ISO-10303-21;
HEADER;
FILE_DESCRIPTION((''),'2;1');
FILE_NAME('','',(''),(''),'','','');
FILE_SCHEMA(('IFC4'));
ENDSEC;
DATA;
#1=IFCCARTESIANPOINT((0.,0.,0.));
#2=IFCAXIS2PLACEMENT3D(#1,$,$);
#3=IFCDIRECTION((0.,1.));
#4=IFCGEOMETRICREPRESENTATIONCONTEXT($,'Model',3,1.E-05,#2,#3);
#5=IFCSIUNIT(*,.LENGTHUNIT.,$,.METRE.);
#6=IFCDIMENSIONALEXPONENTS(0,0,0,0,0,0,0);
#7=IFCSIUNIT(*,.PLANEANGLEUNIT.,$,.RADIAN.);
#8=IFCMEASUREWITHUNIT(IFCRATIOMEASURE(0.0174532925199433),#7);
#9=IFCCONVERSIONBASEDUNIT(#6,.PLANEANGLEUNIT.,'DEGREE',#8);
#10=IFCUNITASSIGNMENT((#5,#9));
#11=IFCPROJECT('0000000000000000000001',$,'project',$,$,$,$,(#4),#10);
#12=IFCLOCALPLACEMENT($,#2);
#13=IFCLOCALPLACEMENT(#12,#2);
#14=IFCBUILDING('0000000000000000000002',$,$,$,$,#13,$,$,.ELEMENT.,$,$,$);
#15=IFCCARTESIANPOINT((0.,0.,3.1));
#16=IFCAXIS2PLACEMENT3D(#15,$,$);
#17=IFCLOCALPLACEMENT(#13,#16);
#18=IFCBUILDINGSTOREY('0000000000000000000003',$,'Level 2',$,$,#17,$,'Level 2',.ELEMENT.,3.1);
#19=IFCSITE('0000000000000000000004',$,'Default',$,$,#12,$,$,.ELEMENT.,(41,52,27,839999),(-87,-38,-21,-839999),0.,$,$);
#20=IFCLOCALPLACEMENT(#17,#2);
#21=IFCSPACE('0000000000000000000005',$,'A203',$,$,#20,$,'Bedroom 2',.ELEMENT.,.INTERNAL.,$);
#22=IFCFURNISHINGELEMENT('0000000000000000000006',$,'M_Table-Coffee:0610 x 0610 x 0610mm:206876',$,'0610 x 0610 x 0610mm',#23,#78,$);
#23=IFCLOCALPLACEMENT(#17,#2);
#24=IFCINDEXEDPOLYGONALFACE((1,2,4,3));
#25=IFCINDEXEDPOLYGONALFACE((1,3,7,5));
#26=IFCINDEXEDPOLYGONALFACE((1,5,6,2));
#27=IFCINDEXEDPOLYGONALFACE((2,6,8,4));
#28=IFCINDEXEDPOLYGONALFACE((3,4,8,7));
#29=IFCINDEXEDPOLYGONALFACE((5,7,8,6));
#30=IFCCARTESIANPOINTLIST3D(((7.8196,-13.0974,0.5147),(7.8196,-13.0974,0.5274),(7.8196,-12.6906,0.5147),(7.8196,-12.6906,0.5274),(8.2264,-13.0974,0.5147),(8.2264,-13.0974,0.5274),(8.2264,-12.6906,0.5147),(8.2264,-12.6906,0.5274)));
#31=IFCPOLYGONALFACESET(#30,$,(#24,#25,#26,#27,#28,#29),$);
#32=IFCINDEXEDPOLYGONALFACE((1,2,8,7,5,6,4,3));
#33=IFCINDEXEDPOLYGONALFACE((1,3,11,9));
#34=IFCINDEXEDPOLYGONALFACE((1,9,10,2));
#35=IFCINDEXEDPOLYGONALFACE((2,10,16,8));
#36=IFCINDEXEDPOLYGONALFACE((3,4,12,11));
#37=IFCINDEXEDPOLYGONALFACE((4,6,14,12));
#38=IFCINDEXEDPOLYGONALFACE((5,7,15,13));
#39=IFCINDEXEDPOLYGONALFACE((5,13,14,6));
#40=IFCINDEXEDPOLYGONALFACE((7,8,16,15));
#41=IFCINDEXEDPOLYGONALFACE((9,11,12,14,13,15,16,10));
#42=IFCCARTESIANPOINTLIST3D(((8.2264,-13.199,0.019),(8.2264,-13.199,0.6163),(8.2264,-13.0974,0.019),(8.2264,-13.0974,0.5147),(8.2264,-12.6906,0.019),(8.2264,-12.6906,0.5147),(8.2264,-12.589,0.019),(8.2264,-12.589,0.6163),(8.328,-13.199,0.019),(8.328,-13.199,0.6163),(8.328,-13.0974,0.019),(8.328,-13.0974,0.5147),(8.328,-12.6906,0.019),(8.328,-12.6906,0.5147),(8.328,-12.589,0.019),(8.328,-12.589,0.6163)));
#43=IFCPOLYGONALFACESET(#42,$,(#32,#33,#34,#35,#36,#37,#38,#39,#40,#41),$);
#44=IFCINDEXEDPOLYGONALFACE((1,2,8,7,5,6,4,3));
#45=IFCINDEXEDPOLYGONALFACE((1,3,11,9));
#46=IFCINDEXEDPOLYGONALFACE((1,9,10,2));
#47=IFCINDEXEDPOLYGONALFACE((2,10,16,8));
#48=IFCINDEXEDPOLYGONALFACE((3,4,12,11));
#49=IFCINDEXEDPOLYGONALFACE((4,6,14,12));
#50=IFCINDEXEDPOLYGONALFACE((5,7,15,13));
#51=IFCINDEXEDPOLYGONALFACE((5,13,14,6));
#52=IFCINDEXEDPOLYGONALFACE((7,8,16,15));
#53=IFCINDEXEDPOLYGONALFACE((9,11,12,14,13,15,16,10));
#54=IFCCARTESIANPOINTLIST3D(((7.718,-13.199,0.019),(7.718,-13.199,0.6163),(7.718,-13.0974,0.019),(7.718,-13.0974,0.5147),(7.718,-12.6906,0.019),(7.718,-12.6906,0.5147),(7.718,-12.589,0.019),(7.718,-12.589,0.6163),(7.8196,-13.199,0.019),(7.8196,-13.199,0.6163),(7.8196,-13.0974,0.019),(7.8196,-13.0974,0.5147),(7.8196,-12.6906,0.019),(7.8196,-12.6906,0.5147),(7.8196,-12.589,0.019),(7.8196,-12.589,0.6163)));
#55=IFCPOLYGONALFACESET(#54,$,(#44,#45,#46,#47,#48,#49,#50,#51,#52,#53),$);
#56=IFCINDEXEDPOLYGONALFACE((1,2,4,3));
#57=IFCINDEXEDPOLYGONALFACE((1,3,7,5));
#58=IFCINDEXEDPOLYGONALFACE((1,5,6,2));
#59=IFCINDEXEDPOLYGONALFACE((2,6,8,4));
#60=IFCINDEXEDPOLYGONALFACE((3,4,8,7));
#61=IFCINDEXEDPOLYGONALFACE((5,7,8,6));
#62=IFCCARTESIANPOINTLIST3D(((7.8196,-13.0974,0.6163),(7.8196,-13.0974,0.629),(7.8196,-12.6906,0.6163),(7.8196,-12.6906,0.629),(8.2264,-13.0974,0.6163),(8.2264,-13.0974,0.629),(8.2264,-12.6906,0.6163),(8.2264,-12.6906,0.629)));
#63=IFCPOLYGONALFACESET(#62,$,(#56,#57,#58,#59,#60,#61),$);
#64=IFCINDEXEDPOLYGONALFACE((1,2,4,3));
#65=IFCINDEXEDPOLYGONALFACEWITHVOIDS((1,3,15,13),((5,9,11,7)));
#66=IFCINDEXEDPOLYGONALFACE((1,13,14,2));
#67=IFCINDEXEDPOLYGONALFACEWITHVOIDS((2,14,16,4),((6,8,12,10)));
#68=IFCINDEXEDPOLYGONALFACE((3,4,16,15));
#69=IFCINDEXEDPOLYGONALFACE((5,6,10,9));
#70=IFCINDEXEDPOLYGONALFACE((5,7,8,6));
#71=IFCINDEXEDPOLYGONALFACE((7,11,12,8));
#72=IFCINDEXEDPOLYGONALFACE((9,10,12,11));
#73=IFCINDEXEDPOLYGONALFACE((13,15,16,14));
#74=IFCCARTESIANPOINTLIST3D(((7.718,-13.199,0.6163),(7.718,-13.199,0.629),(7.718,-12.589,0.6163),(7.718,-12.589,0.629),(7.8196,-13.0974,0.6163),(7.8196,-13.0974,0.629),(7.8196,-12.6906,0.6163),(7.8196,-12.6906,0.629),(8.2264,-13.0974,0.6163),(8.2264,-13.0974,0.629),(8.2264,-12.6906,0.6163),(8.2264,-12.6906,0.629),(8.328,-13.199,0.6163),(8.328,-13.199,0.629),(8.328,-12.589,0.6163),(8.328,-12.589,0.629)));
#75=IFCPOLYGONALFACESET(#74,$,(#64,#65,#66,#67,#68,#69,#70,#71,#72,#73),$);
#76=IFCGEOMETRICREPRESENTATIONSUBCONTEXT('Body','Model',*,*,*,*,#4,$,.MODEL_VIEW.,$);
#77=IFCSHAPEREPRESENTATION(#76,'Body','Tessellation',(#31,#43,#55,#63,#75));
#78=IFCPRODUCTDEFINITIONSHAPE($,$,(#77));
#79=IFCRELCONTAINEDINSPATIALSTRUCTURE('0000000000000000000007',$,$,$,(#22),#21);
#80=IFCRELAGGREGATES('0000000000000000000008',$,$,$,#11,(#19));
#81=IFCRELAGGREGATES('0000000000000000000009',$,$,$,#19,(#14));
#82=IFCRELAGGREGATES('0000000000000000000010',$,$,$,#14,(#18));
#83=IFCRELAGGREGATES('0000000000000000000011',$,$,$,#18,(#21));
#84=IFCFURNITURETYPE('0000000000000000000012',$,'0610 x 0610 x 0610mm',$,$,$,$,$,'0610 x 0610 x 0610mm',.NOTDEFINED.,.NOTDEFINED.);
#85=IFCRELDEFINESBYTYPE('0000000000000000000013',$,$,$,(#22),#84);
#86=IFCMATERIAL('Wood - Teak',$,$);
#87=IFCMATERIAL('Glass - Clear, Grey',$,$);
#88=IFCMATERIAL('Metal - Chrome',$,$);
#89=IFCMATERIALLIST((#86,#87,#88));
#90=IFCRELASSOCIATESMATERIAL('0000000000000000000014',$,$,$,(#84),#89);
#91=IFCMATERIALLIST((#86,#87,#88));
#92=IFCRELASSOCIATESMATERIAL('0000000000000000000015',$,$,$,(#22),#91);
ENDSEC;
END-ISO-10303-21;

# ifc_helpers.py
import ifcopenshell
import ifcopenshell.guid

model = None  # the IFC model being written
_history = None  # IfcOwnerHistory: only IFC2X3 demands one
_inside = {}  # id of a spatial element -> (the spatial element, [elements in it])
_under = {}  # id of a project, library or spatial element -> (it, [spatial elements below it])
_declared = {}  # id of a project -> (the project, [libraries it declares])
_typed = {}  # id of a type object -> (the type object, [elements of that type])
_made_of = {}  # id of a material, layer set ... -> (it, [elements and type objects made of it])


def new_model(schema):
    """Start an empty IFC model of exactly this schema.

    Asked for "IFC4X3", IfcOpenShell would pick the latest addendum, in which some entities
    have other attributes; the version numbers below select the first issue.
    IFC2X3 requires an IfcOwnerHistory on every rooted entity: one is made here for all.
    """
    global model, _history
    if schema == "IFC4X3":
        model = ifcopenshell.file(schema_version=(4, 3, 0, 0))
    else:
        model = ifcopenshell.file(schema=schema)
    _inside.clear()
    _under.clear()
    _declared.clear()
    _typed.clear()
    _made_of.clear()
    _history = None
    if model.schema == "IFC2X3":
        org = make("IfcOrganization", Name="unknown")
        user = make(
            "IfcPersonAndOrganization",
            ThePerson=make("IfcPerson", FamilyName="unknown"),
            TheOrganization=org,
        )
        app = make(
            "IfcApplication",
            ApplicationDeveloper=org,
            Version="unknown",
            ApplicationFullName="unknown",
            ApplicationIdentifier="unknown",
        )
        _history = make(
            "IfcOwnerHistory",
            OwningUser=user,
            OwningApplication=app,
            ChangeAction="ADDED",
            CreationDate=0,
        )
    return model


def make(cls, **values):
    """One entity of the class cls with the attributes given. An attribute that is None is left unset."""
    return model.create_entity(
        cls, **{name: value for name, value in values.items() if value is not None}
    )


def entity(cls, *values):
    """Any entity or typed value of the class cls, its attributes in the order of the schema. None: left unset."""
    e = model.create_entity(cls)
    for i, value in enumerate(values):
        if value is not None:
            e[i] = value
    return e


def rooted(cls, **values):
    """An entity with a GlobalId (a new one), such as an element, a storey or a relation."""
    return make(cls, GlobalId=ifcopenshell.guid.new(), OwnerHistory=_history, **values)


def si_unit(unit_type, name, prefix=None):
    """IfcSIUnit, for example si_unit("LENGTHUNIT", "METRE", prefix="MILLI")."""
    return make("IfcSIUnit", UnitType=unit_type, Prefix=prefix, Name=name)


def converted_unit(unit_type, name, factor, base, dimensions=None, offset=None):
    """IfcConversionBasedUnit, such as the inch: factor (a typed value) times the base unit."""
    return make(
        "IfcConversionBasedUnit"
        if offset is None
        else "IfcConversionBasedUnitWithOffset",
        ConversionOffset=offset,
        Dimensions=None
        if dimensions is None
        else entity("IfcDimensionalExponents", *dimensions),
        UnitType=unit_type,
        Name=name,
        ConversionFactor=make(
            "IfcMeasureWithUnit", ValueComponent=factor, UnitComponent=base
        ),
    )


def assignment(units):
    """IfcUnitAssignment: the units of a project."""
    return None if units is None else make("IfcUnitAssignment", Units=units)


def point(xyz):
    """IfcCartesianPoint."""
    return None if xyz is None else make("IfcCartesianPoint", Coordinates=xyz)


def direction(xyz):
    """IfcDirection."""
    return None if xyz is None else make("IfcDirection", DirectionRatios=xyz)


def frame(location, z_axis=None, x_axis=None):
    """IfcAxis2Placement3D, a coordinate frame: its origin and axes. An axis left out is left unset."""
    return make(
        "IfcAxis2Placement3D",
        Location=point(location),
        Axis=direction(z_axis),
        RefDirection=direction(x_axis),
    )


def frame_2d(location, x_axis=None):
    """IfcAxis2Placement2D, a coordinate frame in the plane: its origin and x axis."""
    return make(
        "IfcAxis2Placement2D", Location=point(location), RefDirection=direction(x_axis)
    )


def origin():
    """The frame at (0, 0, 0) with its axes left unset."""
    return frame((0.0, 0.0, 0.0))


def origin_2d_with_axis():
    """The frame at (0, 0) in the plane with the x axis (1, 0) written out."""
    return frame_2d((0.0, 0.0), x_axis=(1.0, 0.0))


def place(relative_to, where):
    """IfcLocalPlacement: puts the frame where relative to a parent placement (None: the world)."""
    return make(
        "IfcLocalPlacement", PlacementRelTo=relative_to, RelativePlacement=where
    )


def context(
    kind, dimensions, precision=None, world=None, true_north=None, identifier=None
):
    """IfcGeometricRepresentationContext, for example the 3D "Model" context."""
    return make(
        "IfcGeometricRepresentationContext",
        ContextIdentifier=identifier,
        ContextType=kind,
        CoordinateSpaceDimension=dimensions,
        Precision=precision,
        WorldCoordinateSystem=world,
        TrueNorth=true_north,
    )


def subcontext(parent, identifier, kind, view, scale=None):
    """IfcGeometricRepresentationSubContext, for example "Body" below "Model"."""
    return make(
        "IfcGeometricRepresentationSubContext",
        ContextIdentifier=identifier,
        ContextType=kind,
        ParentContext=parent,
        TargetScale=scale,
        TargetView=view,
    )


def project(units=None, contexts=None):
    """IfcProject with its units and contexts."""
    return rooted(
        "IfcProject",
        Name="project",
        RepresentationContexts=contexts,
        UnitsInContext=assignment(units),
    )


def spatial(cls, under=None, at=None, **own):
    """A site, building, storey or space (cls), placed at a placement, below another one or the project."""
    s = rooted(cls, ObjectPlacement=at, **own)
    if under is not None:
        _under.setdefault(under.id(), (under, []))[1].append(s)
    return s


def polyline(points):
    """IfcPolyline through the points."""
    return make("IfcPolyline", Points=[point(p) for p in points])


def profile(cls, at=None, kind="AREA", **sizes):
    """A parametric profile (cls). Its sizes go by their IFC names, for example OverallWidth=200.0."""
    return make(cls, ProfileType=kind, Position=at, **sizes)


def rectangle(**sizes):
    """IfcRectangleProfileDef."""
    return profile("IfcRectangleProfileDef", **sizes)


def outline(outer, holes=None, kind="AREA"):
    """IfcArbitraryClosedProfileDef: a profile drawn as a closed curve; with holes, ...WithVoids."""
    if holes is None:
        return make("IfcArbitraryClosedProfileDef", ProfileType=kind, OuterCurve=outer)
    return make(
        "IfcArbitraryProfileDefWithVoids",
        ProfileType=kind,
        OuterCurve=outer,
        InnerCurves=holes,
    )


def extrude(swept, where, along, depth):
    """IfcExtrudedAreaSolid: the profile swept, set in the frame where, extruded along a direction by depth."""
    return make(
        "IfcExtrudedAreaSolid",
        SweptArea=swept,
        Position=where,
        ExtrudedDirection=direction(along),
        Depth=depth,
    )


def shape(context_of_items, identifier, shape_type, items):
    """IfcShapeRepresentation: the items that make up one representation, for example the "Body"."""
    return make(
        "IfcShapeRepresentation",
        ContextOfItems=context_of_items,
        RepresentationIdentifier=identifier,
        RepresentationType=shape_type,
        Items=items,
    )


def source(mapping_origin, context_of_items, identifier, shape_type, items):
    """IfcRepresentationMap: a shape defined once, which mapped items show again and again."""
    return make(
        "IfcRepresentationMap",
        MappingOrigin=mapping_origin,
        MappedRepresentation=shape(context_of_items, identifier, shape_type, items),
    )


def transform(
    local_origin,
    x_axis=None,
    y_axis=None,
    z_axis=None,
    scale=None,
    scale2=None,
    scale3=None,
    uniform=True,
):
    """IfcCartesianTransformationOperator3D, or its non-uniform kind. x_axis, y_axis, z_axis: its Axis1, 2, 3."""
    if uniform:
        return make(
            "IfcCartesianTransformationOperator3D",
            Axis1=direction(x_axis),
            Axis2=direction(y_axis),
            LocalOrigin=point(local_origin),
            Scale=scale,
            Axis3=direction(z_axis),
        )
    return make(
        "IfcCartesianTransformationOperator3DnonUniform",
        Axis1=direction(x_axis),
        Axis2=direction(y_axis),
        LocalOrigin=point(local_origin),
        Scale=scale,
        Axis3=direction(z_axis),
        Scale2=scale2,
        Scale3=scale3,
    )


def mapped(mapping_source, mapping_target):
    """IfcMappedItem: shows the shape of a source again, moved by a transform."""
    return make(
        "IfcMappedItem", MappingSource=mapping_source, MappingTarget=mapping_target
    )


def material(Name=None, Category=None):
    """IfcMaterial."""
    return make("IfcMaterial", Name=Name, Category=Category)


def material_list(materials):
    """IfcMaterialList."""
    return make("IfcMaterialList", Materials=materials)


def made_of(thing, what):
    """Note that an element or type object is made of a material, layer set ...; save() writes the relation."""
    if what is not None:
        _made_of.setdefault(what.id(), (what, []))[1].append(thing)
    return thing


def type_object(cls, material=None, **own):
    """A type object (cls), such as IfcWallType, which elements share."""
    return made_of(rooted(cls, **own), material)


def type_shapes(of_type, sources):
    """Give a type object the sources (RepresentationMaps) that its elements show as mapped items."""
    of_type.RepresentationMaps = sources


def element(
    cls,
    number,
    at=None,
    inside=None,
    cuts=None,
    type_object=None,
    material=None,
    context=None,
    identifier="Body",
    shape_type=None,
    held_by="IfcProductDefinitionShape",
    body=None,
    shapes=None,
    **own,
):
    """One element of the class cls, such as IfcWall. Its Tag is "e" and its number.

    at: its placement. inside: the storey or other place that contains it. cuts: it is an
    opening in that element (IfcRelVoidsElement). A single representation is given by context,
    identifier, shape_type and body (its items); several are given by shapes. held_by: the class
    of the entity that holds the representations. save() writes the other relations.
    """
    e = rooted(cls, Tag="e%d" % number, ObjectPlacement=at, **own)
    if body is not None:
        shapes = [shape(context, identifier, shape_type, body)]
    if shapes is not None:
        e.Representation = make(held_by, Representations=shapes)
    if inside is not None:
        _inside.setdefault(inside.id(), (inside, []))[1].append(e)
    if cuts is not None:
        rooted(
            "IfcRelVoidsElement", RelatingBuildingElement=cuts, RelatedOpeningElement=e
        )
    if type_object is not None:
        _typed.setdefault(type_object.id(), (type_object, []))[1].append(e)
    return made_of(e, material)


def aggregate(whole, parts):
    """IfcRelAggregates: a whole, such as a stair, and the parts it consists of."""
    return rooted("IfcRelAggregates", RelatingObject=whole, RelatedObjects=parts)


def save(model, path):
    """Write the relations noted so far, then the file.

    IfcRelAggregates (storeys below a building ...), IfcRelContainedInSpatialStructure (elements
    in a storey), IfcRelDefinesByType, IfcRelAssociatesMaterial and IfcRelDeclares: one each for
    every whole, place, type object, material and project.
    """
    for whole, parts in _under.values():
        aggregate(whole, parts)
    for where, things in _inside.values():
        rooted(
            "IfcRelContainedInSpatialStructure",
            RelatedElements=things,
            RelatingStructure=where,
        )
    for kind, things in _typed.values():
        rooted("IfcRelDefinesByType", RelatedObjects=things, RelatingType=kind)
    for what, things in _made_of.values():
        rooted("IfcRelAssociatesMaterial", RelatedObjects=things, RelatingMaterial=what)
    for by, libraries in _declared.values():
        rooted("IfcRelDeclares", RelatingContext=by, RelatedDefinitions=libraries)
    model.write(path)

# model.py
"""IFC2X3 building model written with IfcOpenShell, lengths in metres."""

from ifc_helpers import new_model, entity, si_unit, converted_unit, direction, frame, origin, origin_2d_with_axis, place, context, subcontext, project, spatial, polyline, rectangle, outline, extrude, source, transform, mapped, material, material_list, type_object, type_shapes, element, save


model = new_model("IFC2X3")

# Units and contexts
model_context = context("Model", 3, precision=1e-05, world=origin(), true_north=direction((0.0, 1.0)))
body_context = subcontext(model_context, "Body", "Model", "MODEL_VIEW")
ifc_project = project(units=[si_unit("LENGTHUNIT", "METRE"), converted_unit("PLANEANGLEUNIT", "DEGREE", entity("IfcRatioMeasure", 0.0174532925199433), si_unit("PLANEANGLEUNIT", "RADIAN"), dimensions=[0, 0, 0, 0, 0, 0, 0])], contexts=[model_context])

# Site, building, storey
site_placement = place(None, origin())
site = spatial("IfcSite", under=ifc_project, at=site_placement, Name="Default", CompositionType="ELEMENT", RefLatitude=(41, 52, 27, 839999), RefLongitude=(-87, -38, -21, -839999), RefElevation=0.0)
building_placement = place(site_placement, origin())
building = spatial("IfcBuilding", under=site, at=building_placement, CompositionType="ELEMENT")
storey_placement = place(building_placement, frame((0.0, 0.0, 3.1)))
storey = spatial("IfcBuildingStorey", under=building, at=storey_placement, Name="Level 2", LongName="Level 2", CompositionType="ELEMENT", Elevation=3.1)

# Shared definitions
space_1_placement = place(storey_placement, origin())
space_1 = spatial("IfcSpace", under=storey, at=space_1_placement, Name="A203", LongName="Bedroom 2", CompositionType="ELEMENT", InteriorOrExteriorSpace="INTERNAL")

# Furnishing element
ifc_material_1 = material(Name="Wood - Teak")
ifc_material_2 = material(Name="Glass - Clear, Grey")
ifc_material_3 = material(Name="Metal - Chrome")
ifc_material_list_1 = material_list([ifc_material_1, ifc_material_2, ifc_material_3])
ifc_material_list_2 = material_list([ifc_material_1, ifc_material_2, ifc_material_3])
furniture_type_1 = type_object("IfcFurnitureType", Name="0610 x 0610 x 0610mm", ElementType="0610 x 0610 x 0610mm", material=ifc_material_list_2)
shared_shape_1 = source(origin(), body_context, "Body", "SweptSolid", [
    extrude(rectangle(XDim=0.4068, YDim=0.4068, at=origin_2d_with_axis()), frame((0.0183, 0.0952, 0.4957), z_axis=(0.0, 0.0, 1.0), x_axis=(-1.0, 0.0, 0.0)), (0.0, 0.0, 1.0), 0.0127),
    extrude(outline(polyline([(-0.2732, -0.305), (0.324, -0.305), (0.324, 0.305), (-0.2732, 0.305), (-0.2732, 0.2034), (0.2225, 0.2034), (0.2225, -0.2034), (-0.2732, -0.2034), (-0.2732, -0.305)])), frame((0.2217, 0.0952, 0.2732), z_axis=(1.0, 0.0, 0.0), x_axis=(0.0, 0.0, 1.0)), (0.0, 0.0, 1.0), 0.1016),
    extrude(outline(polyline([(-0.305, -0.3241), (0.305, -0.3241), (0.305, 0.2733), (0.2034, 0.2733), (0.2034, -0.2224), (-0.2034, -0.2224), (-0.2034, 0.2733), (-0.305, 0.2733), (-0.305, -0.3241)])), frame((-0.2867, 0.0952, 0.2733), z_axis=(1.0, 0.0, 0.0), x_axis=(0.0, -1.0, 0.0)), (0.0, 0.0, 1.0), 0.1016),
    extrude(rectangle(XDim=0.4068, YDim=0.4068, at=origin_2d_with_axis()), frame((0.0183, 0.0952, 0.5973), z_axis=(0.0, 0.0, 1.0), x_axis=(-1.0, 0.0, 0.0)), (0.0, 0.0, 1.0), 0.0127),
    extrude(outline(polyline([(-0.305, -0.305), (0.305, -0.305), (0.305, 0.305), (-0.305, 0.305), (-0.305, -0.305)]), holes=[polyline([(-0.2034, -0.2034), (-0.2034, 0.2034), (0.2034, 0.2034), (0.2034, -0.2034), (-0.2034, -0.2034)])]), frame((0.0183, 0.0952, 0.5973), z_axis=(0.0, 0.0, 1.0), x_axis=(-1.0, 0.0, 0.0)), (0.0, 0.0, 1.0), 0.0127),
])
type_shapes(furniture_type_1, [shared_shape_1])
furnishing_1_placement = place(space_1_placement, frame((8.0047, -12.9892, 0.019)))
element("IfcFurnishingElement", 1, at=furnishing_1_placement, inside=space_1, type_object=furniture_type_1, material=ifc_material_list_1, Name="M_Table-Coffee:0610 x 0610 x 0610mm:206876", ObjectType="0610 x 0610 x 0610mm", context=body_context, shape_type="MappedRepresentation", body=[
    mapped(shared_shape_1, transform((0.0, 0.0, 0.0), scale=1.0)),
])

save(model, "model.ifc")
